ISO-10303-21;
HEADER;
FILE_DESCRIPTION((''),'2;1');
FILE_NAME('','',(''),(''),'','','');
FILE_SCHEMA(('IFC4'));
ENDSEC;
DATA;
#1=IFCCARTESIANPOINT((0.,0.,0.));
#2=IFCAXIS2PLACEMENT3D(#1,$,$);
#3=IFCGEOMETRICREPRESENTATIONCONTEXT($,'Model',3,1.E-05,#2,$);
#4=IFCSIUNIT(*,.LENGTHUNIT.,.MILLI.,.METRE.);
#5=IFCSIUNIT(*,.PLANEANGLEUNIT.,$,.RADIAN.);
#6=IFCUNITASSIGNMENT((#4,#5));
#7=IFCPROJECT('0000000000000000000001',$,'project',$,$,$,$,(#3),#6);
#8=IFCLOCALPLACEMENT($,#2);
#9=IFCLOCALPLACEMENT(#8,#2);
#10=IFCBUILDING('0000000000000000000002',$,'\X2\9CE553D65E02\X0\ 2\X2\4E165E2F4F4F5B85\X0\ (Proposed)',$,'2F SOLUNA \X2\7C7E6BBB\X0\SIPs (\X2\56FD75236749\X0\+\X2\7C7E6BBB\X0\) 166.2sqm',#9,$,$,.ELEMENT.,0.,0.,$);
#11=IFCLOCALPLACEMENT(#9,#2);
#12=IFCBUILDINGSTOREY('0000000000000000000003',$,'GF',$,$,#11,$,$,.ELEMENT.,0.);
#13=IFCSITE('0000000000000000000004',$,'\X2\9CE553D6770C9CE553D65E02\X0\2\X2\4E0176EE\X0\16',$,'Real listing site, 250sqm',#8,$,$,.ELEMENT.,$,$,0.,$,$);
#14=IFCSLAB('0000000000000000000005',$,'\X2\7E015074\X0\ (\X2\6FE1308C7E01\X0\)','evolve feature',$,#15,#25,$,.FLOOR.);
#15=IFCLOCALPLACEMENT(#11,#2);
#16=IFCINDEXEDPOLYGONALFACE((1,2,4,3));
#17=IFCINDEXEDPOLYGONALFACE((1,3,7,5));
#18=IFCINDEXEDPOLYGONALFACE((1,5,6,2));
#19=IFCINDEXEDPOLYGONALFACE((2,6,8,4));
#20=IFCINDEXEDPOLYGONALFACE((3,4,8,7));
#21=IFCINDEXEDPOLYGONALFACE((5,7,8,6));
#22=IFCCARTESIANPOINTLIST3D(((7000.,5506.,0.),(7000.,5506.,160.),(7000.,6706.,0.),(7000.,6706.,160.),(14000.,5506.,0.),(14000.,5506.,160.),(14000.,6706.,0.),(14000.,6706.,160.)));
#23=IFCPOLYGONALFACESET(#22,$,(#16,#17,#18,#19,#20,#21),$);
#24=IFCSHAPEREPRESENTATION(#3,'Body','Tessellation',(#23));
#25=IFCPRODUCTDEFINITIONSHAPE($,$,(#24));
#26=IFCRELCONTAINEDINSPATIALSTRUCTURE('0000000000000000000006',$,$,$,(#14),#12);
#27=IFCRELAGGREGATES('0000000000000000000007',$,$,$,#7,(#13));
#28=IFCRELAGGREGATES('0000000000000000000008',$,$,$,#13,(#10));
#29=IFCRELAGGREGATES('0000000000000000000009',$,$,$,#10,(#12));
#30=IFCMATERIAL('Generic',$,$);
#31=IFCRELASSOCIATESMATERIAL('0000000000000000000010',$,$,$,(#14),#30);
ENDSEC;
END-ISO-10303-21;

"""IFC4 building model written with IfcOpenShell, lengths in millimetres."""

from ifc_helpers import new_model, si_unit, frame, frame_2d, origin, place, context, project, spatial, rectangle, extrude, material, element, save


model = new_model("IFC4")

# Units and contexts
model_context = context("Model", 3, precision=1e-05, world=origin())
ifc_project = project(units=[si_unit("LENGTHUNIT", "METRE", prefix="MILLI"), si_unit("PLANEANGLEUNIT", "RADIAN")], contexts=[model_context])

# Site, building, storey
site_placement = place(None, origin())
site = spatial("IfcSite", under=ifc_project, at=site_placement, Name="鳥取県鳥取市2丁目16", ObjectType="Real listing site, 250sqm", CompositionType="ELEMENT", RefElevation=0.0)
building_placement = place(site_placement, origin())
building = spatial("IfcBuilding", under=site, at=building_placement, Name="鳥取市 2世帯住宅 (Proposed)", ObjectType="2F SOLUNA 籾殻SIPs (国産杉+籾殻) 166.2sqm", CompositionType="ELEMENT", ElevationOfRefHeight=0.0, ElevationOfTerrain=0.0)
storey_placement = place(building_placement, origin())
storey = spatial("IfcBuildingStorey", under=building, at=storey_placement, Name="GF", CompositionType="ELEMENT", Elevation=0.0)

# Slab
ifc_material_1 = material(Name="Generic")
slab_1_placement = place(storey_placement, frame((3500.0, 2753.0, 0.0)))
element("IfcSlab", 1, at=slab_1_placement, inside=storey, material=ifc_material_1, Name="縁側 (濡れ縁)", Description="evolve feature", PredefinedType="FLOOR", context=model_context, shape_type="SweptSolid", body=[
    extrude(rectangle(XDim=7000.0, YDim=1200.0, at=frame_2d((3500.0, 600.0))), frame((3500.0, 2753.0, 0.0)), (0.0, 0.0, 1.0), 160.0),
])

save(model, "model.ifc")
